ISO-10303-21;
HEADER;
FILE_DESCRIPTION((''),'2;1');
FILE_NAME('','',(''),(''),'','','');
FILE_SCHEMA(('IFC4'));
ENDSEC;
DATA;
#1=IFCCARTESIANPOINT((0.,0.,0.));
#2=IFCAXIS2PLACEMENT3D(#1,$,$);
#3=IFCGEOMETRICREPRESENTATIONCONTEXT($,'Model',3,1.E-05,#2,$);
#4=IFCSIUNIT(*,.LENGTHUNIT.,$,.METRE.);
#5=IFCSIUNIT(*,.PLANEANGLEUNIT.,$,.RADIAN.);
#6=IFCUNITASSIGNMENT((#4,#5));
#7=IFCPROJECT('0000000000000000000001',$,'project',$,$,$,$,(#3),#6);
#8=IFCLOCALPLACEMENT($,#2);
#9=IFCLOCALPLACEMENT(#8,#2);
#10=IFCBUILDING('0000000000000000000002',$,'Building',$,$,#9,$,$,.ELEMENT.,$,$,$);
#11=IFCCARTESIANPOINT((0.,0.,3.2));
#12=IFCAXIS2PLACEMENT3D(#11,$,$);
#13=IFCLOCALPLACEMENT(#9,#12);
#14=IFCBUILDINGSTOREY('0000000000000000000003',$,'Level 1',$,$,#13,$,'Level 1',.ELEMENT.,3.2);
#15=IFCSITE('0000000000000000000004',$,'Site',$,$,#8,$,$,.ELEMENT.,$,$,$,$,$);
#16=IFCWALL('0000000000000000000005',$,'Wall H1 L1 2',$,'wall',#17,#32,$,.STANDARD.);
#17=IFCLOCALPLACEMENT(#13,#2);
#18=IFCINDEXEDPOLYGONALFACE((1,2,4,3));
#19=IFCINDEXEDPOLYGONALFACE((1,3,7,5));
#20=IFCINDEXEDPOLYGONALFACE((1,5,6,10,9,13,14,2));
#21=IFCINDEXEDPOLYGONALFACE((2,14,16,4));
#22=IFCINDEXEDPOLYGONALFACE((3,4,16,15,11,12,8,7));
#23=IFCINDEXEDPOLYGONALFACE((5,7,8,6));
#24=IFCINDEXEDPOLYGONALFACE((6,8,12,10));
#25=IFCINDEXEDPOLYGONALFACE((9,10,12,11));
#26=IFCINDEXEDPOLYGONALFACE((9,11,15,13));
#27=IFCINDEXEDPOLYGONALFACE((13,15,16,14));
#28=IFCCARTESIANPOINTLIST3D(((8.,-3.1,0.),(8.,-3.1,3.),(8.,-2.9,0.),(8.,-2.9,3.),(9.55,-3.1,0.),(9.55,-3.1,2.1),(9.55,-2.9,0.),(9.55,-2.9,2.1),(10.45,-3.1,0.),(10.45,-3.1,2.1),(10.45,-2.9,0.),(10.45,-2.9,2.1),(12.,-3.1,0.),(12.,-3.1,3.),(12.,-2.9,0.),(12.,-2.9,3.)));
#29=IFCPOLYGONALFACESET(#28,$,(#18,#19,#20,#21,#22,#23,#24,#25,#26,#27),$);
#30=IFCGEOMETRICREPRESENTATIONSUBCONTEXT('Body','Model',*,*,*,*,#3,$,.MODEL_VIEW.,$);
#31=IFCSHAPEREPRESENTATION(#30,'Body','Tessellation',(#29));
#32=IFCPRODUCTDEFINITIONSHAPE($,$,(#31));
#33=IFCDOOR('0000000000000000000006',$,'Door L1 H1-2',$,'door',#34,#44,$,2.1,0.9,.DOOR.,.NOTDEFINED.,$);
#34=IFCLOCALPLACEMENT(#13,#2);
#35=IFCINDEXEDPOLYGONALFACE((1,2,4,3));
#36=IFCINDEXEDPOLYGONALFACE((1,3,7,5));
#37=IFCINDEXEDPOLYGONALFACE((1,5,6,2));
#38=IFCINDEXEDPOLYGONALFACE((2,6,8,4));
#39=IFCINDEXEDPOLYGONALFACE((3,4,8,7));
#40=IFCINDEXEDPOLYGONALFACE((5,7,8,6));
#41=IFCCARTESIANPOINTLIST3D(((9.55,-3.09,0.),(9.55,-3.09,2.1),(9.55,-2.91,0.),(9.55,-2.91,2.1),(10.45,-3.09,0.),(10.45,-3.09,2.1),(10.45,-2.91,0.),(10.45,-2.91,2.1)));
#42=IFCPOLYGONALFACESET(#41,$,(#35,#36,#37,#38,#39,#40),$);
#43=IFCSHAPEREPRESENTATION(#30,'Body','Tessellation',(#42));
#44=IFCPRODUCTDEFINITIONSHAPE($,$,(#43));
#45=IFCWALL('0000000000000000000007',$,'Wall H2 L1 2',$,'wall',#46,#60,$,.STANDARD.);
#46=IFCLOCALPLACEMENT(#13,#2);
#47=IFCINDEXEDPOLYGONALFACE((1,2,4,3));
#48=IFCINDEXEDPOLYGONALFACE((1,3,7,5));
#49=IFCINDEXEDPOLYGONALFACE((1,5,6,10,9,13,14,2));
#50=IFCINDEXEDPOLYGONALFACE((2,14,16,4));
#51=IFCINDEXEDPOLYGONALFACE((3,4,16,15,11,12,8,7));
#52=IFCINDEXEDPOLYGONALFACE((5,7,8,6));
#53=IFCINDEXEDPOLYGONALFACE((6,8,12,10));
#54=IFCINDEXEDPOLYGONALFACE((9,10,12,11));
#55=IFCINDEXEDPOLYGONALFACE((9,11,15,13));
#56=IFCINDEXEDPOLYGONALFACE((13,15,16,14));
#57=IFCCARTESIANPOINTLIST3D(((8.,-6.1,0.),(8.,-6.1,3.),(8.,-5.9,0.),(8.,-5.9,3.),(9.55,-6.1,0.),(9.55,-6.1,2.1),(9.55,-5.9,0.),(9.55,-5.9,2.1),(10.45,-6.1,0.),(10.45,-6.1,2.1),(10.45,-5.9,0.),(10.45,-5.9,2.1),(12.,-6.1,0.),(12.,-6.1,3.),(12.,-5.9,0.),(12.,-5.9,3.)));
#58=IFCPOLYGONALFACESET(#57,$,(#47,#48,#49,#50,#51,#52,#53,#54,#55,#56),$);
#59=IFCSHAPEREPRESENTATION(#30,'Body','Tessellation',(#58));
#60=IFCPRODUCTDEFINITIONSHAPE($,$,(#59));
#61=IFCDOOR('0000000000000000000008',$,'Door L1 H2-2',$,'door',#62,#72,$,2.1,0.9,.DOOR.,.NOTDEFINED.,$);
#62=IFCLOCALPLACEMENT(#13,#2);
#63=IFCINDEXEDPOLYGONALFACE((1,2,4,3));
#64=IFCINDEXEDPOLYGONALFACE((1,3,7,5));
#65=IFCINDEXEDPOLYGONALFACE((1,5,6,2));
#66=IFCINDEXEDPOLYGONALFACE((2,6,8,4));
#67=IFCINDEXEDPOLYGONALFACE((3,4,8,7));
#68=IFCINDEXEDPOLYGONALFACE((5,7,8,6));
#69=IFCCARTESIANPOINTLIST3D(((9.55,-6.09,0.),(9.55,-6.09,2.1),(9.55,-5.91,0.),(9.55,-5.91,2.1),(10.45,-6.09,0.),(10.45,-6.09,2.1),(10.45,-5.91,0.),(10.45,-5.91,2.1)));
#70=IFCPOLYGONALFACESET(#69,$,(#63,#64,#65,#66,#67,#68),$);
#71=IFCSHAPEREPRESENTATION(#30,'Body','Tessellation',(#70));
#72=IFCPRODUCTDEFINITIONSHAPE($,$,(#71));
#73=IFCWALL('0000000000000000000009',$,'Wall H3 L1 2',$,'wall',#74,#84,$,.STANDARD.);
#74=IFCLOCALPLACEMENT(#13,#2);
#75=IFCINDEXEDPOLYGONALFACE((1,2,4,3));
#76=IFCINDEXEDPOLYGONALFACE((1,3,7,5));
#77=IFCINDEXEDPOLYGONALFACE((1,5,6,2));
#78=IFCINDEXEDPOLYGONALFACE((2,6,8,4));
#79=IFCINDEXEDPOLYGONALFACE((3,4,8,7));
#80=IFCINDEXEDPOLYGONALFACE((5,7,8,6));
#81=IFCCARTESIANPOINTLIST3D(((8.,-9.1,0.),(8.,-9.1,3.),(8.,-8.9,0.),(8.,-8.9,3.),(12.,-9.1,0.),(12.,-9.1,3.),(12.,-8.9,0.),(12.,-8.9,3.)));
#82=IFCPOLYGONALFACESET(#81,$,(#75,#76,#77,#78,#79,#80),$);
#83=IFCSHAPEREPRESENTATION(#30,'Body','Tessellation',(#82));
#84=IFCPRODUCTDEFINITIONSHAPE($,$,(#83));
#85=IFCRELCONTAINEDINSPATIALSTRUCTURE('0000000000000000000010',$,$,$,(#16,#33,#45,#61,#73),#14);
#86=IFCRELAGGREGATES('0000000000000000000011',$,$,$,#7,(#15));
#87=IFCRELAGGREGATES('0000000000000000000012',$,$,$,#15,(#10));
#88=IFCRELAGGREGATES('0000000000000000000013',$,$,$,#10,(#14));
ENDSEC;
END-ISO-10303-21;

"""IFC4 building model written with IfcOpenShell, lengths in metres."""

from ifc_helpers import new_model, si_unit, frame, frame_2d, origin, origin_2d, place, context, subcontext, project, spatial, rectangle, extrude, element, fill, save


model = new_model("IFC4")

# Units and contexts
model_context = context("Model", 3, precision=1e-05, world=origin())
body_context = subcontext(model_context, "Body", "Model", "MODEL_VIEW")
ifc_project = project(units=[si_unit("LENGTHUNIT", "METRE"), si_unit("PLANEANGLEUNIT", "RADIAN")], contexts=[model_context])

# Site, building, storey
site_placement = place(None, origin())
site = spatial("IfcSite", under=ifc_project, at=site_placement, Name="Site", CompositionType="ELEMENT")
building_placement = place(site_placement, origin())
building = spatial("IfcBuilding", under=site, at=building_placement, Name="Building", CompositionType="ELEMENT")
storey_placement = place(building_placement, frame((0.0, 0.0, 3.2)))
storey = spatial("IfcBuildingStorey", under=building, at=storey_placement, Name="Level 1", LongName="Level 1", CompositionType="ELEMENT", Elevation=3.2)

# Walls, openings, doors
wall_1_placement = place(storey_placement, frame((8.0, -3.0, 0.0), z_axis=(0.0, 0.0, 1.0), x_axis=(1.0, 0.0, 0.0)))
wall_1 = element("IfcWall", 1, at=wall_1_placement, inside=storey, Name="Wall H1 L1 2", ObjectType="wall", PredefinedType="STANDARD", context=body_context, shape_type="SweptSolid", body=[
    extrude(rectangle(XDim=4.0, YDim=0.2, at=frame_2d((2.0, 0.0))), origin(), (0.0, 0.0, 1.0), 3.0),
])
opening_1_placement = place(storey_placement, frame((10.0, -3.0, 0.0), z_axis=(0.0, 0.0, 1.0), x_axis=(1.0, 0.0, 0.0)))
opening_1 = element("IfcOpeningElement", 2, at=opening_1_placement, cuts=wall_1, ObjectType="Opening", PredefinedType="OPENING", context=body_context, shape_type="SweptSolid", body=[
    extrude(rectangle(XDim=0.9, YDim=0.22, at=origin_2d()), origin(), (0.0, 0.0, 1.0), 2.1),
])
door_1_placement = place(storey_placement, frame((10.0, -3.0, 0.0), z_axis=(0.0, 0.0, 1.0), x_axis=(1.0, 0.0, 0.0)))
door_1 = element("IfcDoor", 3, at=door_1_placement, inside=storey, Name="Door L1 H1-2", ObjectType="door", OperationType="NOTDEFINED", OverallHeight=2.1, OverallWidth=0.9, PredefinedType="DOOR", context=body_context, shape_type="SweptSolid", body=[
    extrude(rectangle(XDim=0.9, YDim=0.18, at=origin_2d()), origin(), (0.0, 0.0, 1.0), 2.1),
])
fill(opening_1, door_1)
wall_2_placement = place(storey_placement, frame((8.0, -6.0, 0.0), z_axis=(0.0, 0.0, 1.0), x_axis=(1.0, 0.0, 0.0)))
wall_2 = element("IfcWall", 4, at=wall_2_placement, inside=storey, Name="Wall H2 L1 2", ObjectType="wall", PredefinedType="STANDARD", context=body_context, shape_type="SweptSolid", body=[
    extrude(rectangle(XDim=4.0, YDim=0.2, at=frame_2d((2.0, 0.0))), origin(), (0.0, 0.0, 1.0), 3.0),
])
opening_2_placement = place(storey_placement, frame((10.0, -6.0, 0.0), z_axis=(0.0, 0.0, 1.0), x_axis=(1.0, 0.0, 0.0)))
opening_2 = element("IfcOpeningElement", 5, at=opening_2_placement, cuts=wall_2, ObjectType="Opening", PredefinedType="OPENING", context=body_context, shape_type="SweptSolid", body=[
    extrude(rectangle(XDim=0.9, YDim=0.22, at=origin_2d()), origin(), (0.0, 0.0, 1.0), 2.1),
])
door_2_placement = place(storey_placement, frame((10.0, -6.0, 0.0), z_axis=(0.0, 0.0, 1.0), x_axis=(1.0, 0.0, 0.0)))
door_2 = element("IfcDoor", 6, at=door_2_placement, inside=storey, Name="Door L1 H2-2", ObjectType="door", OperationType="NOTDEFINED", OverallHeight=2.1, OverallWidth=0.9, PredefinedType="DOOR", context=body_context, shape_type="SweptSolid", body=[
    extrude(rectangle(XDim=0.9, YDim=0.18, at=origin_2d()), origin(), (0.0, 0.0, 1.0), 2.1),
])
fill(opening_2, door_2)

# Wall
wall_3_placement = place(storey_placement, frame((8.0, -9.0, 0.0), z_axis=(0.0, 0.0, 1.0), x_axis=(1.0, 0.0, 0.0)))
element("IfcWall", 7, at=wall_3_placement, inside=storey, Name="Wall H3 L1 2", ObjectType="wall", PredefinedType="STANDARD", context=body_context, shape_type="SweptSolid", body=[
    extrude(rectangle(XDim=4.0, YDim=0.2, at=frame_2d((2.0, 0.0))), origin(), (0.0, 0.0, 1.0), 3.0),
])

save(model, "model.ifc")
